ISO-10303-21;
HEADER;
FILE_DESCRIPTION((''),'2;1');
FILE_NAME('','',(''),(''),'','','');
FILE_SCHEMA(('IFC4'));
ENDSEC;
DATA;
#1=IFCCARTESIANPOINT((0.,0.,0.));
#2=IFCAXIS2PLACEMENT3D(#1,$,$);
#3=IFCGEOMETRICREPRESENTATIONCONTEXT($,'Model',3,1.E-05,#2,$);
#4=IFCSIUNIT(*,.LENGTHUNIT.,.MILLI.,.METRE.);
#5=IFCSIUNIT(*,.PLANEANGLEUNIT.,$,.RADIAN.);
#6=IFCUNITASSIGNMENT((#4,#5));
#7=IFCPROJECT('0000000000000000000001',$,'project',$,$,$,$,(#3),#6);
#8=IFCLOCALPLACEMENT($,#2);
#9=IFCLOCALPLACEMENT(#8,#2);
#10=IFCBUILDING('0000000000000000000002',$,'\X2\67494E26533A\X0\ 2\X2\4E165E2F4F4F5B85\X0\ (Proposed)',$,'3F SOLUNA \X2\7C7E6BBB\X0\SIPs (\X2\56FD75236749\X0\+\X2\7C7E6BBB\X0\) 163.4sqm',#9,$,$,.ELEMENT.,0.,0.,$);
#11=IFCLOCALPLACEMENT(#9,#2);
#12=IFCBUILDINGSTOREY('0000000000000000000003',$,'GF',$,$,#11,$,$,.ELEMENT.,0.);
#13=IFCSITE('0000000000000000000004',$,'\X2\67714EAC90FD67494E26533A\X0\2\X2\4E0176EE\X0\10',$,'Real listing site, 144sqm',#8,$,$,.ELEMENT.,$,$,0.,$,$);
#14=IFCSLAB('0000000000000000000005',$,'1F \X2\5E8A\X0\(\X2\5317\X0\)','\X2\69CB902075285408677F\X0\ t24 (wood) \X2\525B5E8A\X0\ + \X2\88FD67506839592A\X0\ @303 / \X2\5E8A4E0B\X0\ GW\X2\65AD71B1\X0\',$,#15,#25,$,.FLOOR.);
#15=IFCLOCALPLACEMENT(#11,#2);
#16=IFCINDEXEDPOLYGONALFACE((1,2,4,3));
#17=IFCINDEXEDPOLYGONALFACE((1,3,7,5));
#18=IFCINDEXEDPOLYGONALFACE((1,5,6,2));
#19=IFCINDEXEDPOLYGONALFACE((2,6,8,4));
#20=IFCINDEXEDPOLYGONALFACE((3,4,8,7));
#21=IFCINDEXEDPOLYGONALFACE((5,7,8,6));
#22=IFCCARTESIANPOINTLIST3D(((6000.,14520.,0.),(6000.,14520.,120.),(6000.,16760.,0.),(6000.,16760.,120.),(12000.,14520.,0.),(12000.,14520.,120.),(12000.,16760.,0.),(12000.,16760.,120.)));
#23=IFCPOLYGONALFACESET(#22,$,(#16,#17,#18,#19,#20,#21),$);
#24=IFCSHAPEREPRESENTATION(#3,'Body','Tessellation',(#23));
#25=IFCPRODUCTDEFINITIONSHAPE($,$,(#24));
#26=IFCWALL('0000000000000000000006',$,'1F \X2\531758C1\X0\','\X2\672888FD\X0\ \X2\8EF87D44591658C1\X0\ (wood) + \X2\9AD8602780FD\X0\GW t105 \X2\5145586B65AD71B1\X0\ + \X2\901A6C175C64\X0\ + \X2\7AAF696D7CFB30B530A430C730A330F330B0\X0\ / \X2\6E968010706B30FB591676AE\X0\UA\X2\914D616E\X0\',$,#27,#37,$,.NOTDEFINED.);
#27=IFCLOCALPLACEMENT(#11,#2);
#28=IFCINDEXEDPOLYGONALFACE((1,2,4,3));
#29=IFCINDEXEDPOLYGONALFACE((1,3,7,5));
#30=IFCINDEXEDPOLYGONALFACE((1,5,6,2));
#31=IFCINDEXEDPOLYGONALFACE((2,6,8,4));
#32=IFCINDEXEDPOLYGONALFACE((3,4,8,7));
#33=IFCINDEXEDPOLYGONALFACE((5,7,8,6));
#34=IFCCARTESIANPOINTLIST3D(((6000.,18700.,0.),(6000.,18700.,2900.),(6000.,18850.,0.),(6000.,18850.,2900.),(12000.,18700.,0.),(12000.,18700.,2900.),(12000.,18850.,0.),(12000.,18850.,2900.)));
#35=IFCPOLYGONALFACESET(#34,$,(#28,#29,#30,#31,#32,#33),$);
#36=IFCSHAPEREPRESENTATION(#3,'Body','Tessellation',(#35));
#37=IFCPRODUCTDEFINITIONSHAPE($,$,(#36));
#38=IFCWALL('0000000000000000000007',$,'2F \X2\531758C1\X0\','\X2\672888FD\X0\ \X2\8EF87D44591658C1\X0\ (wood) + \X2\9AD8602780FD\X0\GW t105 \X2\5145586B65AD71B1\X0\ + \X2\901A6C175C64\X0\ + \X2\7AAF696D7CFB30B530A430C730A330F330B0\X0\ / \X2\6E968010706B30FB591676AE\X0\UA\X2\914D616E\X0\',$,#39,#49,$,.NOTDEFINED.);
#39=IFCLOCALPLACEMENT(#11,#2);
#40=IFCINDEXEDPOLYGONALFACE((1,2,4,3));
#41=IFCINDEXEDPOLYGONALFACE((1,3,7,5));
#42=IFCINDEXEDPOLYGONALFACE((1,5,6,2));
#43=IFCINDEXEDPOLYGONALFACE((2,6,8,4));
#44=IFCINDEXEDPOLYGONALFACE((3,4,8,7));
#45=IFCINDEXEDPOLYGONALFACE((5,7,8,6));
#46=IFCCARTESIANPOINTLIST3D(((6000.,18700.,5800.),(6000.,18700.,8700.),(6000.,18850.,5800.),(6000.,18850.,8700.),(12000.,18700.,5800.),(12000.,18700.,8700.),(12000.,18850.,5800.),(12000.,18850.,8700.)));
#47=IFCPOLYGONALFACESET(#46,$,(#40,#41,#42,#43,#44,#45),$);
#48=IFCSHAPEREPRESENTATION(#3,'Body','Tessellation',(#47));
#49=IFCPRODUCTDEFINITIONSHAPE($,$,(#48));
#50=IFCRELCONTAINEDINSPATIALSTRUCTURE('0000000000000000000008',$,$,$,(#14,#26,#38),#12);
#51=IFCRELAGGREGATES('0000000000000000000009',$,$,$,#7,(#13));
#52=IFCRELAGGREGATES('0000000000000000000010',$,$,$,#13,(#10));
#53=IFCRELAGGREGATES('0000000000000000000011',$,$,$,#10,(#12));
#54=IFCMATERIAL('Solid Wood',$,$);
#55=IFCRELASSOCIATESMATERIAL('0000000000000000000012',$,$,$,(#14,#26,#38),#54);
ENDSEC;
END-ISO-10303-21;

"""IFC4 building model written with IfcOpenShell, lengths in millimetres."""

from ifc_helpers import new_model, si_unit, frame, frame_2d, origin, place, context, project, spatial, rectangle, extrude, material, element, save


model = new_model("IFC4")

# Units and contexts
model_context = context("Model", 3, precision=1e-05, world=origin())
ifc_project = project(units=[si_unit("LENGTHUNIT", "METRE", prefix="MILLI"), si_unit("PLANEANGLEUNIT", "RADIAN")], contexts=[model_context])

# Site, building, storey
site_placement = place(None, origin())
site = spatial("IfcSite", under=ifc_project, at=site_placement, Name="東京都杉並区2丁目10", ObjectType="Real listing site, 144sqm", CompositionType="ELEMENT", RefElevation=0.0)
building_placement = place(site_placement, origin())
building = spatial("IfcBuilding", under=site, at=building_placement, Name="杉並区 2世帯住宅 (Proposed)", ObjectType="3F SOLUNA 籾殻SIPs (国産杉+籾殻) 163.4sqm", CompositionType="ELEMENT", ElevationOfRefHeight=0.0, ElevationOfTerrain=0.0)
storey_placement = place(building_placement, origin())
storey = spatial("IfcBuildingStorey", under=building, at=storey_placement, Name="GF", CompositionType="ELEMENT", Elevation=0.0)

# Slab
ifc_material_1 = material(Name="Solid Wood")
slab_1_placement = place(storey_placement, frame((3000.0, 7260.0, 0.0)))
element("IfcSlab", 1, at=slab_1_placement, inside=storey, material=ifc_material_1, Name="1F 床(北)", Description="構造用合板 t24 (wood) 剛床 + 製材根太 @303 / 床下 GW断熱", PredefinedType="FLOOR", context=model_context, shape_type="SweptSolid", body=[
    extrude(rectangle(XDim=6000.0, YDim=2240.0, at=frame_2d((3000.0, 1120.0))), frame((3000.0, 7260.0, 0.0)), (0.0, 0.0, 1.0), 120.0),
])

# Wall
wall_1_placement = place(storey_placement, frame((3000.0, 9350.0, 0.0)))
element("IfcWall", 2, at=wall_1_placement, inside=storey, material=ifc_material_1, Name="1F 北壁", Description="木製 軸組外壁 (wood) + 高性能GW t105 充填断熱 + 通気層 + 窯業系サイディング / 準耐火・外皮UA配慮", PredefinedType="NOTDEFINED", context=model_context, shape_type="SweptSolid", body=[
    extrude(rectangle(XDim=6000.0, YDim=150.0, at=frame_2d((3000.0, 75.0))), frame((3000.0, 9350.0, 0.0)), (0.0, 0.0, 1.0), 2900.0),
])

# Wall
wall_2_placement = place(storey_placement, frame((3000.0, 9350.0, 2900.0)))
element("IfcWall", 3, at=wall_2_placement, inside=storey, material=ifc_material_1, Name="2F 北壁", Description="木製 軸組外壁 (wood) + 高性能GW t105 充填断熱 + 通気層 + 窯業系サイディング / 準耐火・外皮UA配慮", PredefinedType="NOTDEFINED", context=model_context, shape_type="SweptSolid", body=[
    extrude(rectangle(XDim=6000.0, YDim=150.0, at=frame_2d((3000.0, 75.0))), frame((3000.0, 9350.0, 2900.0)), (0.0, 0.0, 1.0), 2900.0),
])

save(model, "model.ifc")
